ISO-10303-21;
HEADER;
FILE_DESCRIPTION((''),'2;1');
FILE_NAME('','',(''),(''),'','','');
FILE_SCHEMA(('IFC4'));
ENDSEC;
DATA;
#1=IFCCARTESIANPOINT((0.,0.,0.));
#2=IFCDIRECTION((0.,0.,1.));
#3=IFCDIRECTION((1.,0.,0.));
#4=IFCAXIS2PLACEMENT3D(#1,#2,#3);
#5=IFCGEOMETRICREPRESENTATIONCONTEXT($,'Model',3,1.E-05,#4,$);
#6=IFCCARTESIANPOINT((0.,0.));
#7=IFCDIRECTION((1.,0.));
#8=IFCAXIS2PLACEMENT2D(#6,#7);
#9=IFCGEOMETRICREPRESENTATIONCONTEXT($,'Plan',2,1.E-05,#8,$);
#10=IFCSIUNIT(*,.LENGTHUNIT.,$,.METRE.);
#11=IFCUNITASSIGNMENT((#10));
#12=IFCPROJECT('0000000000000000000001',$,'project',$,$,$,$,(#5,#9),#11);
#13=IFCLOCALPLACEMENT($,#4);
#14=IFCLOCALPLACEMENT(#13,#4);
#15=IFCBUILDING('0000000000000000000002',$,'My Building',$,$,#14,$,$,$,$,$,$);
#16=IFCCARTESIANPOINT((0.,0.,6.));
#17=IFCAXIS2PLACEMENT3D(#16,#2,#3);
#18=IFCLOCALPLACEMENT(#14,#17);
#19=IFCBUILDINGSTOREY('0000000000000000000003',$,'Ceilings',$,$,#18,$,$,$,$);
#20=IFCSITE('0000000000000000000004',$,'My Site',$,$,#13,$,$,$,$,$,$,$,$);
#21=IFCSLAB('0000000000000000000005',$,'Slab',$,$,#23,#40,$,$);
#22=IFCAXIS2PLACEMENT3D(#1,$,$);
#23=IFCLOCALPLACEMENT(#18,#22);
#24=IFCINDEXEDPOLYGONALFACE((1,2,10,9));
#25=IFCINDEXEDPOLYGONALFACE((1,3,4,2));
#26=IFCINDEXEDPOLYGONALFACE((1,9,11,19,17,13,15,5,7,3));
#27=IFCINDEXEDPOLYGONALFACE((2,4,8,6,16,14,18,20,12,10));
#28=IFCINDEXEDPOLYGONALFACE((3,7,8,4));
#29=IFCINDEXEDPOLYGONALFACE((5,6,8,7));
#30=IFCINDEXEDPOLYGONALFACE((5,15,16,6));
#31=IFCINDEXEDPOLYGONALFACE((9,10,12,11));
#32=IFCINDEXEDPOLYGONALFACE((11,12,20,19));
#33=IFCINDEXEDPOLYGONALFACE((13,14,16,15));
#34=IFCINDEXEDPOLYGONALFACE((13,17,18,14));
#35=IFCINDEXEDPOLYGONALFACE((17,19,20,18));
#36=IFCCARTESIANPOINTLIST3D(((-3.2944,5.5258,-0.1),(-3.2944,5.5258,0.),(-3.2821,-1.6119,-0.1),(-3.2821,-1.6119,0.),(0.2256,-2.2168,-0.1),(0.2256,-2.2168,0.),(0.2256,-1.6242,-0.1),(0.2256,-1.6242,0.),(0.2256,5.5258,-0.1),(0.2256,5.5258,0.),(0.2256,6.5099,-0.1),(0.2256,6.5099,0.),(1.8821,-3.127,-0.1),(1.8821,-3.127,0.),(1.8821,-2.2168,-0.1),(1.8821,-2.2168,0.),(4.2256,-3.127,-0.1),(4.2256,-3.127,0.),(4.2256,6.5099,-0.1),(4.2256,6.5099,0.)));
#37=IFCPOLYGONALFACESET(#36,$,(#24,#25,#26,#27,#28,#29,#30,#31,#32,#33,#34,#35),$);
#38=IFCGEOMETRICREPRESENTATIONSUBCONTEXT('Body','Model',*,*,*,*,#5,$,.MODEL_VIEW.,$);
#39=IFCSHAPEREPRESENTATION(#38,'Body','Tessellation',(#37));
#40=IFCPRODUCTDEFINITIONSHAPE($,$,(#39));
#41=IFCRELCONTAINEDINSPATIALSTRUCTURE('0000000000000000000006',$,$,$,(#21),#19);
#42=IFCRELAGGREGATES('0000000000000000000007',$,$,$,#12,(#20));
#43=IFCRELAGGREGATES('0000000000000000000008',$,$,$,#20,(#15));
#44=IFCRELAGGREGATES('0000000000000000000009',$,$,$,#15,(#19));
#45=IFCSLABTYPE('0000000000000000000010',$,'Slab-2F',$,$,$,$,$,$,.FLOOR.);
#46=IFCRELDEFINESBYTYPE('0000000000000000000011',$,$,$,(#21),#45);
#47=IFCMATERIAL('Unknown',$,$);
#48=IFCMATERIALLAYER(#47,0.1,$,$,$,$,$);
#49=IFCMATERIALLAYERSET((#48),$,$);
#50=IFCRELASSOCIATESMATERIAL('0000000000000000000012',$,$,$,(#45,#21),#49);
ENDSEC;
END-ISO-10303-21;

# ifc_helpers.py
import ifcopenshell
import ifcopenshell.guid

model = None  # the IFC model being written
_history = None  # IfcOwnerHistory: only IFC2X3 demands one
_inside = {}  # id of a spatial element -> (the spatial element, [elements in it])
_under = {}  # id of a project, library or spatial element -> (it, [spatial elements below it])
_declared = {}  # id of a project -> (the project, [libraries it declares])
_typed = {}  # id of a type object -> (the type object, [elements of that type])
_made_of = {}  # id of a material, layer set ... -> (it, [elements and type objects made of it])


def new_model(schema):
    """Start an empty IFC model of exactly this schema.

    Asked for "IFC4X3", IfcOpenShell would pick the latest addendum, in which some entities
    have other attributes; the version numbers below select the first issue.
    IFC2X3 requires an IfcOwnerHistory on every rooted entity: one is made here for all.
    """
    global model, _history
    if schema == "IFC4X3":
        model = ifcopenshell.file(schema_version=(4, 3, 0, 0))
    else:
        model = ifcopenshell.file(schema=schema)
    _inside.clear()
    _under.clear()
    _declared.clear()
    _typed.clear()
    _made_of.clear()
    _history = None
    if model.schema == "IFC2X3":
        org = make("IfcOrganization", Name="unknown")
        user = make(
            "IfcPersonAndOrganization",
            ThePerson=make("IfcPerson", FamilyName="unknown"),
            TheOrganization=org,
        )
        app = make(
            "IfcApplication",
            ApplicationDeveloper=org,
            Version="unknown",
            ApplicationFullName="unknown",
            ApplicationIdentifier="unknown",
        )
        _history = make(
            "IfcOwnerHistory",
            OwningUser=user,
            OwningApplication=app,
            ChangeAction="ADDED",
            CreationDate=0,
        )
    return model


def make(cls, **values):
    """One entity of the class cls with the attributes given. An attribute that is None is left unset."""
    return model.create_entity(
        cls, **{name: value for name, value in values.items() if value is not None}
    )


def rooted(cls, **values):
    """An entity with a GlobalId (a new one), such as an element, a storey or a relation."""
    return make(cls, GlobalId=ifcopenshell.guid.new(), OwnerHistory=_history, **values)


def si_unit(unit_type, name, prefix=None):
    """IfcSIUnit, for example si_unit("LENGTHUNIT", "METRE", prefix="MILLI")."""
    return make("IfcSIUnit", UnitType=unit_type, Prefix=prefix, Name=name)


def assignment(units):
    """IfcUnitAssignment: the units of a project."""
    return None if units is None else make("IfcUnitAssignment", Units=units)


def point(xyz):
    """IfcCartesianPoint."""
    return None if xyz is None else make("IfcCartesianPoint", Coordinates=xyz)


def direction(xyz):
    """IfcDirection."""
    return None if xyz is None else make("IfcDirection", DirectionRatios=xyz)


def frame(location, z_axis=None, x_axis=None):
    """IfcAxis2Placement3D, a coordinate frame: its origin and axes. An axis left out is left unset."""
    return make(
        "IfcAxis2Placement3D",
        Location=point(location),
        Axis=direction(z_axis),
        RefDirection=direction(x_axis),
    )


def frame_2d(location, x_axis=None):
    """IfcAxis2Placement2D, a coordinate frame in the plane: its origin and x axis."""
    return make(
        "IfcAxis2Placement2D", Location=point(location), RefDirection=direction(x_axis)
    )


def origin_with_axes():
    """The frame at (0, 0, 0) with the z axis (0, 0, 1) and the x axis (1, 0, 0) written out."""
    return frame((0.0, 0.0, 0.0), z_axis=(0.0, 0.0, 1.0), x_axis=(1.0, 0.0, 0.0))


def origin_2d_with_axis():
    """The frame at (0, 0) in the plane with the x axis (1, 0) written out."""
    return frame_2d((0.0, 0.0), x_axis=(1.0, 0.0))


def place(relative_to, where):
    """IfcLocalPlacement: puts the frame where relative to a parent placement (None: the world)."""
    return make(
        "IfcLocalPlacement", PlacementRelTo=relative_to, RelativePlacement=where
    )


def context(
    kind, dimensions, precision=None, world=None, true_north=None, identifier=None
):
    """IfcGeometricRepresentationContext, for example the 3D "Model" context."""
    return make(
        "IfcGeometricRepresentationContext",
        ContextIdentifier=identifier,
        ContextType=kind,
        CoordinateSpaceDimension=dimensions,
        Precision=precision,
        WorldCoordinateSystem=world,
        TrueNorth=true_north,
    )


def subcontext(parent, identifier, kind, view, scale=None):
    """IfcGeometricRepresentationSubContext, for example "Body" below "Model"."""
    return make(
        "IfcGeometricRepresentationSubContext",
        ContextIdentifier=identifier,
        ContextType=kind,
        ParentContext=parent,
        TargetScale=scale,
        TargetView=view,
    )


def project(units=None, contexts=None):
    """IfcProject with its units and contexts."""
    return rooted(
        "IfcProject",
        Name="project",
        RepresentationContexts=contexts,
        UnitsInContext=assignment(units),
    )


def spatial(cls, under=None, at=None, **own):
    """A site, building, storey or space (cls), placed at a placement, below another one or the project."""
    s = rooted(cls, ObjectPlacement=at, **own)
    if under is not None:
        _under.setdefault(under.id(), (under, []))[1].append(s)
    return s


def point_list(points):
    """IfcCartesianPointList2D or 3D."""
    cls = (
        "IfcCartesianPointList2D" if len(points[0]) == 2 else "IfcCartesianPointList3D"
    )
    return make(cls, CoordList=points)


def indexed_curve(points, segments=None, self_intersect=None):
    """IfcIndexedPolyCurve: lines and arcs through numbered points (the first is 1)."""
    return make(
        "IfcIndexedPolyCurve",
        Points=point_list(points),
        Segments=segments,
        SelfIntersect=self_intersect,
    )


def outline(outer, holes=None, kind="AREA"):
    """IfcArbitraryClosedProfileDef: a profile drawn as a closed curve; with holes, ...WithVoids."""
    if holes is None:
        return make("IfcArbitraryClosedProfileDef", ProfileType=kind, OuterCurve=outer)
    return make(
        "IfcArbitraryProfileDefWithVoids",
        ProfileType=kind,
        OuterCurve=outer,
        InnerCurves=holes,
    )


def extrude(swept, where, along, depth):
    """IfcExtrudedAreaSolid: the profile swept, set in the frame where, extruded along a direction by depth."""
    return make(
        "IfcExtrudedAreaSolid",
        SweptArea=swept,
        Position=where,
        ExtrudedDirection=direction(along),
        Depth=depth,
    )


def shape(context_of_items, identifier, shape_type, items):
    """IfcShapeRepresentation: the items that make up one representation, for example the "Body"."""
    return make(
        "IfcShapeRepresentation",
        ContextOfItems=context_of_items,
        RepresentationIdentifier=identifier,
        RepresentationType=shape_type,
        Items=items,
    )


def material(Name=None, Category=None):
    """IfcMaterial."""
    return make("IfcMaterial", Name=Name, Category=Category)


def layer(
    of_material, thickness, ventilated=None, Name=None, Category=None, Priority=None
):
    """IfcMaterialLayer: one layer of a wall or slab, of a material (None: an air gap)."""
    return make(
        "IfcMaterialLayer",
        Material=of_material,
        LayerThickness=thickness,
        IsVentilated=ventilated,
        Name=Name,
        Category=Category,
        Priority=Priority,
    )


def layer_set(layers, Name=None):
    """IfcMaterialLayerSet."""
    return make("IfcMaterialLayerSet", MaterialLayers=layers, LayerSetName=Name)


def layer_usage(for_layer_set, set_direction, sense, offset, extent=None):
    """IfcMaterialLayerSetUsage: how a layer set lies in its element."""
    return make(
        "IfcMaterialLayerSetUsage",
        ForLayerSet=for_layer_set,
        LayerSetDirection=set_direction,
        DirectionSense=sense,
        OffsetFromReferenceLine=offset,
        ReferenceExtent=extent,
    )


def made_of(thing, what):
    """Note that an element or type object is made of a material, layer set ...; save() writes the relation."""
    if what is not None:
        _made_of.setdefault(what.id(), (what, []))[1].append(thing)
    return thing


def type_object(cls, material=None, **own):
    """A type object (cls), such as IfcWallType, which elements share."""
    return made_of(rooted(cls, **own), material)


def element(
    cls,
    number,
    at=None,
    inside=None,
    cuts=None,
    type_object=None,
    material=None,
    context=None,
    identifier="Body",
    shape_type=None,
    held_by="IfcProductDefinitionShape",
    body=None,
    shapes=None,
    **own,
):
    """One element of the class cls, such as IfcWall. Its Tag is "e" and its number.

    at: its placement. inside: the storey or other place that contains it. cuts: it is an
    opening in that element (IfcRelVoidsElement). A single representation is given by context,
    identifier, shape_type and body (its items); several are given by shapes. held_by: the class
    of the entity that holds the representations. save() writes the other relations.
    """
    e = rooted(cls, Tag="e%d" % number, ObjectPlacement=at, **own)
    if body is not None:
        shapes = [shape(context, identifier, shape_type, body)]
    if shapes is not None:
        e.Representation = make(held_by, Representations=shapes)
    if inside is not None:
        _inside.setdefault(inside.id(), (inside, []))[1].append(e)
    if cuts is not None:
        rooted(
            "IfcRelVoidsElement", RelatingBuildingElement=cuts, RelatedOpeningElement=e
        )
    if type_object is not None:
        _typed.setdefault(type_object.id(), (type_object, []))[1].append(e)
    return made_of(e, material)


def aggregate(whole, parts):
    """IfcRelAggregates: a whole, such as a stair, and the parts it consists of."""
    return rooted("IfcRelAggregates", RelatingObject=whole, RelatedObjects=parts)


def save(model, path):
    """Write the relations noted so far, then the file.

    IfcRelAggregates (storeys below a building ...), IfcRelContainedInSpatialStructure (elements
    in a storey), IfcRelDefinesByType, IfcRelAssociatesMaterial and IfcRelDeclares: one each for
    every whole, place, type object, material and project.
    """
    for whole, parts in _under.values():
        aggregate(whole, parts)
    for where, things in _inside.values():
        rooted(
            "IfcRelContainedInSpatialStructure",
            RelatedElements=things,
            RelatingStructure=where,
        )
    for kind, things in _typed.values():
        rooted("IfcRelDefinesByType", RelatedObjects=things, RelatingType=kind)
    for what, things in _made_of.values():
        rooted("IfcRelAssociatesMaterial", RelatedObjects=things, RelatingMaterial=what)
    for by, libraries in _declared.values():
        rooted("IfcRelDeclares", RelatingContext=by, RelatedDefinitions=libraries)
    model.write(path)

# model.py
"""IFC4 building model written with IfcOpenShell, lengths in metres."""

from ifc_helpers import new_model, si_unit, frame, origin_with_axes, origin_2d_with_axis, place, context, subcontext, project, spatial, indexed_curve, outline, extrude, material, layer, layer_set, layer_usage, type_object, element, save


model = new_model("IFC4")

# Units and contexts
model_context = context("Model", 3, precision=1e-05, world=origin_with_axes())
plan_context = context("Plan", 2, precision=1e-05, world=origin_2d_with_axis())
body_context = subcontext(model_context, "Body", "Model", "MODEL_VIEW")
ifc_project = project(units=[si_unit("LENGTHUNIT", "METRE")], contexts=[model_context, plan_context])

# Site, building, storey
site_placement = place(None, origin_with_axes())
site = spatial("IfcSite", under=ifc_project, at=site_placement, Name="My Site")
building_placement = place(site_placement, origin_with_axes())
building = spatial("IfcBuilding", under=site, at=building_placement, Name="My Building")
storey_placement = place(building_placement, frame((0.0, 0.0, 6.0), z_axis=(0.0, 0.0, 1.0), x_axis=(1.0, 0.0, 0.0)))
storey = spatial("IfcBuildingStorey", under=building, at=storey_placement, Name="Ceilings")

# Slab
ifc_material = material(Name="Unknown")
ifc_layer = layer(ifc_material, 0.1)
ifc_layer_set = layer_set([ifc_layer])
ifc_layer_usage = layer_usage(ifc_layer_set, "AXIS3", "POSITIVE", -0.1)
slab_type = type_object("IfcSlabType", Name="Slab-2F", PredefinedType="FLOOR", material=ifc_layer_set)
slab_placement = place(storey_placement, frame((4.2256, -3.127, 0.0), z_axis=(0.0, 0.0, 1.0), x_axis=(1.0, 0.0, 0.0)))
element("IfcSlab", 1, at=slab_placement, inside=storey, type_object=slab_type, material=ifc_layer_usage, Name="Slab", context=body_context, shape_type="SweptSolid", body=[
    extrude(outline(indexed_curve([(0.0, 0.0), (0.0, 9.6369), (-4.0, 9.6369), (-4.0, 8.6528), (-7.52, 8.6528), (-7.5077, 1.5151), (-4.0, 1.5028), (-4.0, 0.9102), (-2.3435, 0.9102), (-2.3435, 0.0), (0.0, 0.0)])), frame((0.0, 0.0, -0.1), z_axis=(0.0, 0.0, 1.0), x_axis=(1.0, 0.0, 0.0)), (0.0, 0.0, 1.0), 0.1),
])

save(model, "model.ifc")
